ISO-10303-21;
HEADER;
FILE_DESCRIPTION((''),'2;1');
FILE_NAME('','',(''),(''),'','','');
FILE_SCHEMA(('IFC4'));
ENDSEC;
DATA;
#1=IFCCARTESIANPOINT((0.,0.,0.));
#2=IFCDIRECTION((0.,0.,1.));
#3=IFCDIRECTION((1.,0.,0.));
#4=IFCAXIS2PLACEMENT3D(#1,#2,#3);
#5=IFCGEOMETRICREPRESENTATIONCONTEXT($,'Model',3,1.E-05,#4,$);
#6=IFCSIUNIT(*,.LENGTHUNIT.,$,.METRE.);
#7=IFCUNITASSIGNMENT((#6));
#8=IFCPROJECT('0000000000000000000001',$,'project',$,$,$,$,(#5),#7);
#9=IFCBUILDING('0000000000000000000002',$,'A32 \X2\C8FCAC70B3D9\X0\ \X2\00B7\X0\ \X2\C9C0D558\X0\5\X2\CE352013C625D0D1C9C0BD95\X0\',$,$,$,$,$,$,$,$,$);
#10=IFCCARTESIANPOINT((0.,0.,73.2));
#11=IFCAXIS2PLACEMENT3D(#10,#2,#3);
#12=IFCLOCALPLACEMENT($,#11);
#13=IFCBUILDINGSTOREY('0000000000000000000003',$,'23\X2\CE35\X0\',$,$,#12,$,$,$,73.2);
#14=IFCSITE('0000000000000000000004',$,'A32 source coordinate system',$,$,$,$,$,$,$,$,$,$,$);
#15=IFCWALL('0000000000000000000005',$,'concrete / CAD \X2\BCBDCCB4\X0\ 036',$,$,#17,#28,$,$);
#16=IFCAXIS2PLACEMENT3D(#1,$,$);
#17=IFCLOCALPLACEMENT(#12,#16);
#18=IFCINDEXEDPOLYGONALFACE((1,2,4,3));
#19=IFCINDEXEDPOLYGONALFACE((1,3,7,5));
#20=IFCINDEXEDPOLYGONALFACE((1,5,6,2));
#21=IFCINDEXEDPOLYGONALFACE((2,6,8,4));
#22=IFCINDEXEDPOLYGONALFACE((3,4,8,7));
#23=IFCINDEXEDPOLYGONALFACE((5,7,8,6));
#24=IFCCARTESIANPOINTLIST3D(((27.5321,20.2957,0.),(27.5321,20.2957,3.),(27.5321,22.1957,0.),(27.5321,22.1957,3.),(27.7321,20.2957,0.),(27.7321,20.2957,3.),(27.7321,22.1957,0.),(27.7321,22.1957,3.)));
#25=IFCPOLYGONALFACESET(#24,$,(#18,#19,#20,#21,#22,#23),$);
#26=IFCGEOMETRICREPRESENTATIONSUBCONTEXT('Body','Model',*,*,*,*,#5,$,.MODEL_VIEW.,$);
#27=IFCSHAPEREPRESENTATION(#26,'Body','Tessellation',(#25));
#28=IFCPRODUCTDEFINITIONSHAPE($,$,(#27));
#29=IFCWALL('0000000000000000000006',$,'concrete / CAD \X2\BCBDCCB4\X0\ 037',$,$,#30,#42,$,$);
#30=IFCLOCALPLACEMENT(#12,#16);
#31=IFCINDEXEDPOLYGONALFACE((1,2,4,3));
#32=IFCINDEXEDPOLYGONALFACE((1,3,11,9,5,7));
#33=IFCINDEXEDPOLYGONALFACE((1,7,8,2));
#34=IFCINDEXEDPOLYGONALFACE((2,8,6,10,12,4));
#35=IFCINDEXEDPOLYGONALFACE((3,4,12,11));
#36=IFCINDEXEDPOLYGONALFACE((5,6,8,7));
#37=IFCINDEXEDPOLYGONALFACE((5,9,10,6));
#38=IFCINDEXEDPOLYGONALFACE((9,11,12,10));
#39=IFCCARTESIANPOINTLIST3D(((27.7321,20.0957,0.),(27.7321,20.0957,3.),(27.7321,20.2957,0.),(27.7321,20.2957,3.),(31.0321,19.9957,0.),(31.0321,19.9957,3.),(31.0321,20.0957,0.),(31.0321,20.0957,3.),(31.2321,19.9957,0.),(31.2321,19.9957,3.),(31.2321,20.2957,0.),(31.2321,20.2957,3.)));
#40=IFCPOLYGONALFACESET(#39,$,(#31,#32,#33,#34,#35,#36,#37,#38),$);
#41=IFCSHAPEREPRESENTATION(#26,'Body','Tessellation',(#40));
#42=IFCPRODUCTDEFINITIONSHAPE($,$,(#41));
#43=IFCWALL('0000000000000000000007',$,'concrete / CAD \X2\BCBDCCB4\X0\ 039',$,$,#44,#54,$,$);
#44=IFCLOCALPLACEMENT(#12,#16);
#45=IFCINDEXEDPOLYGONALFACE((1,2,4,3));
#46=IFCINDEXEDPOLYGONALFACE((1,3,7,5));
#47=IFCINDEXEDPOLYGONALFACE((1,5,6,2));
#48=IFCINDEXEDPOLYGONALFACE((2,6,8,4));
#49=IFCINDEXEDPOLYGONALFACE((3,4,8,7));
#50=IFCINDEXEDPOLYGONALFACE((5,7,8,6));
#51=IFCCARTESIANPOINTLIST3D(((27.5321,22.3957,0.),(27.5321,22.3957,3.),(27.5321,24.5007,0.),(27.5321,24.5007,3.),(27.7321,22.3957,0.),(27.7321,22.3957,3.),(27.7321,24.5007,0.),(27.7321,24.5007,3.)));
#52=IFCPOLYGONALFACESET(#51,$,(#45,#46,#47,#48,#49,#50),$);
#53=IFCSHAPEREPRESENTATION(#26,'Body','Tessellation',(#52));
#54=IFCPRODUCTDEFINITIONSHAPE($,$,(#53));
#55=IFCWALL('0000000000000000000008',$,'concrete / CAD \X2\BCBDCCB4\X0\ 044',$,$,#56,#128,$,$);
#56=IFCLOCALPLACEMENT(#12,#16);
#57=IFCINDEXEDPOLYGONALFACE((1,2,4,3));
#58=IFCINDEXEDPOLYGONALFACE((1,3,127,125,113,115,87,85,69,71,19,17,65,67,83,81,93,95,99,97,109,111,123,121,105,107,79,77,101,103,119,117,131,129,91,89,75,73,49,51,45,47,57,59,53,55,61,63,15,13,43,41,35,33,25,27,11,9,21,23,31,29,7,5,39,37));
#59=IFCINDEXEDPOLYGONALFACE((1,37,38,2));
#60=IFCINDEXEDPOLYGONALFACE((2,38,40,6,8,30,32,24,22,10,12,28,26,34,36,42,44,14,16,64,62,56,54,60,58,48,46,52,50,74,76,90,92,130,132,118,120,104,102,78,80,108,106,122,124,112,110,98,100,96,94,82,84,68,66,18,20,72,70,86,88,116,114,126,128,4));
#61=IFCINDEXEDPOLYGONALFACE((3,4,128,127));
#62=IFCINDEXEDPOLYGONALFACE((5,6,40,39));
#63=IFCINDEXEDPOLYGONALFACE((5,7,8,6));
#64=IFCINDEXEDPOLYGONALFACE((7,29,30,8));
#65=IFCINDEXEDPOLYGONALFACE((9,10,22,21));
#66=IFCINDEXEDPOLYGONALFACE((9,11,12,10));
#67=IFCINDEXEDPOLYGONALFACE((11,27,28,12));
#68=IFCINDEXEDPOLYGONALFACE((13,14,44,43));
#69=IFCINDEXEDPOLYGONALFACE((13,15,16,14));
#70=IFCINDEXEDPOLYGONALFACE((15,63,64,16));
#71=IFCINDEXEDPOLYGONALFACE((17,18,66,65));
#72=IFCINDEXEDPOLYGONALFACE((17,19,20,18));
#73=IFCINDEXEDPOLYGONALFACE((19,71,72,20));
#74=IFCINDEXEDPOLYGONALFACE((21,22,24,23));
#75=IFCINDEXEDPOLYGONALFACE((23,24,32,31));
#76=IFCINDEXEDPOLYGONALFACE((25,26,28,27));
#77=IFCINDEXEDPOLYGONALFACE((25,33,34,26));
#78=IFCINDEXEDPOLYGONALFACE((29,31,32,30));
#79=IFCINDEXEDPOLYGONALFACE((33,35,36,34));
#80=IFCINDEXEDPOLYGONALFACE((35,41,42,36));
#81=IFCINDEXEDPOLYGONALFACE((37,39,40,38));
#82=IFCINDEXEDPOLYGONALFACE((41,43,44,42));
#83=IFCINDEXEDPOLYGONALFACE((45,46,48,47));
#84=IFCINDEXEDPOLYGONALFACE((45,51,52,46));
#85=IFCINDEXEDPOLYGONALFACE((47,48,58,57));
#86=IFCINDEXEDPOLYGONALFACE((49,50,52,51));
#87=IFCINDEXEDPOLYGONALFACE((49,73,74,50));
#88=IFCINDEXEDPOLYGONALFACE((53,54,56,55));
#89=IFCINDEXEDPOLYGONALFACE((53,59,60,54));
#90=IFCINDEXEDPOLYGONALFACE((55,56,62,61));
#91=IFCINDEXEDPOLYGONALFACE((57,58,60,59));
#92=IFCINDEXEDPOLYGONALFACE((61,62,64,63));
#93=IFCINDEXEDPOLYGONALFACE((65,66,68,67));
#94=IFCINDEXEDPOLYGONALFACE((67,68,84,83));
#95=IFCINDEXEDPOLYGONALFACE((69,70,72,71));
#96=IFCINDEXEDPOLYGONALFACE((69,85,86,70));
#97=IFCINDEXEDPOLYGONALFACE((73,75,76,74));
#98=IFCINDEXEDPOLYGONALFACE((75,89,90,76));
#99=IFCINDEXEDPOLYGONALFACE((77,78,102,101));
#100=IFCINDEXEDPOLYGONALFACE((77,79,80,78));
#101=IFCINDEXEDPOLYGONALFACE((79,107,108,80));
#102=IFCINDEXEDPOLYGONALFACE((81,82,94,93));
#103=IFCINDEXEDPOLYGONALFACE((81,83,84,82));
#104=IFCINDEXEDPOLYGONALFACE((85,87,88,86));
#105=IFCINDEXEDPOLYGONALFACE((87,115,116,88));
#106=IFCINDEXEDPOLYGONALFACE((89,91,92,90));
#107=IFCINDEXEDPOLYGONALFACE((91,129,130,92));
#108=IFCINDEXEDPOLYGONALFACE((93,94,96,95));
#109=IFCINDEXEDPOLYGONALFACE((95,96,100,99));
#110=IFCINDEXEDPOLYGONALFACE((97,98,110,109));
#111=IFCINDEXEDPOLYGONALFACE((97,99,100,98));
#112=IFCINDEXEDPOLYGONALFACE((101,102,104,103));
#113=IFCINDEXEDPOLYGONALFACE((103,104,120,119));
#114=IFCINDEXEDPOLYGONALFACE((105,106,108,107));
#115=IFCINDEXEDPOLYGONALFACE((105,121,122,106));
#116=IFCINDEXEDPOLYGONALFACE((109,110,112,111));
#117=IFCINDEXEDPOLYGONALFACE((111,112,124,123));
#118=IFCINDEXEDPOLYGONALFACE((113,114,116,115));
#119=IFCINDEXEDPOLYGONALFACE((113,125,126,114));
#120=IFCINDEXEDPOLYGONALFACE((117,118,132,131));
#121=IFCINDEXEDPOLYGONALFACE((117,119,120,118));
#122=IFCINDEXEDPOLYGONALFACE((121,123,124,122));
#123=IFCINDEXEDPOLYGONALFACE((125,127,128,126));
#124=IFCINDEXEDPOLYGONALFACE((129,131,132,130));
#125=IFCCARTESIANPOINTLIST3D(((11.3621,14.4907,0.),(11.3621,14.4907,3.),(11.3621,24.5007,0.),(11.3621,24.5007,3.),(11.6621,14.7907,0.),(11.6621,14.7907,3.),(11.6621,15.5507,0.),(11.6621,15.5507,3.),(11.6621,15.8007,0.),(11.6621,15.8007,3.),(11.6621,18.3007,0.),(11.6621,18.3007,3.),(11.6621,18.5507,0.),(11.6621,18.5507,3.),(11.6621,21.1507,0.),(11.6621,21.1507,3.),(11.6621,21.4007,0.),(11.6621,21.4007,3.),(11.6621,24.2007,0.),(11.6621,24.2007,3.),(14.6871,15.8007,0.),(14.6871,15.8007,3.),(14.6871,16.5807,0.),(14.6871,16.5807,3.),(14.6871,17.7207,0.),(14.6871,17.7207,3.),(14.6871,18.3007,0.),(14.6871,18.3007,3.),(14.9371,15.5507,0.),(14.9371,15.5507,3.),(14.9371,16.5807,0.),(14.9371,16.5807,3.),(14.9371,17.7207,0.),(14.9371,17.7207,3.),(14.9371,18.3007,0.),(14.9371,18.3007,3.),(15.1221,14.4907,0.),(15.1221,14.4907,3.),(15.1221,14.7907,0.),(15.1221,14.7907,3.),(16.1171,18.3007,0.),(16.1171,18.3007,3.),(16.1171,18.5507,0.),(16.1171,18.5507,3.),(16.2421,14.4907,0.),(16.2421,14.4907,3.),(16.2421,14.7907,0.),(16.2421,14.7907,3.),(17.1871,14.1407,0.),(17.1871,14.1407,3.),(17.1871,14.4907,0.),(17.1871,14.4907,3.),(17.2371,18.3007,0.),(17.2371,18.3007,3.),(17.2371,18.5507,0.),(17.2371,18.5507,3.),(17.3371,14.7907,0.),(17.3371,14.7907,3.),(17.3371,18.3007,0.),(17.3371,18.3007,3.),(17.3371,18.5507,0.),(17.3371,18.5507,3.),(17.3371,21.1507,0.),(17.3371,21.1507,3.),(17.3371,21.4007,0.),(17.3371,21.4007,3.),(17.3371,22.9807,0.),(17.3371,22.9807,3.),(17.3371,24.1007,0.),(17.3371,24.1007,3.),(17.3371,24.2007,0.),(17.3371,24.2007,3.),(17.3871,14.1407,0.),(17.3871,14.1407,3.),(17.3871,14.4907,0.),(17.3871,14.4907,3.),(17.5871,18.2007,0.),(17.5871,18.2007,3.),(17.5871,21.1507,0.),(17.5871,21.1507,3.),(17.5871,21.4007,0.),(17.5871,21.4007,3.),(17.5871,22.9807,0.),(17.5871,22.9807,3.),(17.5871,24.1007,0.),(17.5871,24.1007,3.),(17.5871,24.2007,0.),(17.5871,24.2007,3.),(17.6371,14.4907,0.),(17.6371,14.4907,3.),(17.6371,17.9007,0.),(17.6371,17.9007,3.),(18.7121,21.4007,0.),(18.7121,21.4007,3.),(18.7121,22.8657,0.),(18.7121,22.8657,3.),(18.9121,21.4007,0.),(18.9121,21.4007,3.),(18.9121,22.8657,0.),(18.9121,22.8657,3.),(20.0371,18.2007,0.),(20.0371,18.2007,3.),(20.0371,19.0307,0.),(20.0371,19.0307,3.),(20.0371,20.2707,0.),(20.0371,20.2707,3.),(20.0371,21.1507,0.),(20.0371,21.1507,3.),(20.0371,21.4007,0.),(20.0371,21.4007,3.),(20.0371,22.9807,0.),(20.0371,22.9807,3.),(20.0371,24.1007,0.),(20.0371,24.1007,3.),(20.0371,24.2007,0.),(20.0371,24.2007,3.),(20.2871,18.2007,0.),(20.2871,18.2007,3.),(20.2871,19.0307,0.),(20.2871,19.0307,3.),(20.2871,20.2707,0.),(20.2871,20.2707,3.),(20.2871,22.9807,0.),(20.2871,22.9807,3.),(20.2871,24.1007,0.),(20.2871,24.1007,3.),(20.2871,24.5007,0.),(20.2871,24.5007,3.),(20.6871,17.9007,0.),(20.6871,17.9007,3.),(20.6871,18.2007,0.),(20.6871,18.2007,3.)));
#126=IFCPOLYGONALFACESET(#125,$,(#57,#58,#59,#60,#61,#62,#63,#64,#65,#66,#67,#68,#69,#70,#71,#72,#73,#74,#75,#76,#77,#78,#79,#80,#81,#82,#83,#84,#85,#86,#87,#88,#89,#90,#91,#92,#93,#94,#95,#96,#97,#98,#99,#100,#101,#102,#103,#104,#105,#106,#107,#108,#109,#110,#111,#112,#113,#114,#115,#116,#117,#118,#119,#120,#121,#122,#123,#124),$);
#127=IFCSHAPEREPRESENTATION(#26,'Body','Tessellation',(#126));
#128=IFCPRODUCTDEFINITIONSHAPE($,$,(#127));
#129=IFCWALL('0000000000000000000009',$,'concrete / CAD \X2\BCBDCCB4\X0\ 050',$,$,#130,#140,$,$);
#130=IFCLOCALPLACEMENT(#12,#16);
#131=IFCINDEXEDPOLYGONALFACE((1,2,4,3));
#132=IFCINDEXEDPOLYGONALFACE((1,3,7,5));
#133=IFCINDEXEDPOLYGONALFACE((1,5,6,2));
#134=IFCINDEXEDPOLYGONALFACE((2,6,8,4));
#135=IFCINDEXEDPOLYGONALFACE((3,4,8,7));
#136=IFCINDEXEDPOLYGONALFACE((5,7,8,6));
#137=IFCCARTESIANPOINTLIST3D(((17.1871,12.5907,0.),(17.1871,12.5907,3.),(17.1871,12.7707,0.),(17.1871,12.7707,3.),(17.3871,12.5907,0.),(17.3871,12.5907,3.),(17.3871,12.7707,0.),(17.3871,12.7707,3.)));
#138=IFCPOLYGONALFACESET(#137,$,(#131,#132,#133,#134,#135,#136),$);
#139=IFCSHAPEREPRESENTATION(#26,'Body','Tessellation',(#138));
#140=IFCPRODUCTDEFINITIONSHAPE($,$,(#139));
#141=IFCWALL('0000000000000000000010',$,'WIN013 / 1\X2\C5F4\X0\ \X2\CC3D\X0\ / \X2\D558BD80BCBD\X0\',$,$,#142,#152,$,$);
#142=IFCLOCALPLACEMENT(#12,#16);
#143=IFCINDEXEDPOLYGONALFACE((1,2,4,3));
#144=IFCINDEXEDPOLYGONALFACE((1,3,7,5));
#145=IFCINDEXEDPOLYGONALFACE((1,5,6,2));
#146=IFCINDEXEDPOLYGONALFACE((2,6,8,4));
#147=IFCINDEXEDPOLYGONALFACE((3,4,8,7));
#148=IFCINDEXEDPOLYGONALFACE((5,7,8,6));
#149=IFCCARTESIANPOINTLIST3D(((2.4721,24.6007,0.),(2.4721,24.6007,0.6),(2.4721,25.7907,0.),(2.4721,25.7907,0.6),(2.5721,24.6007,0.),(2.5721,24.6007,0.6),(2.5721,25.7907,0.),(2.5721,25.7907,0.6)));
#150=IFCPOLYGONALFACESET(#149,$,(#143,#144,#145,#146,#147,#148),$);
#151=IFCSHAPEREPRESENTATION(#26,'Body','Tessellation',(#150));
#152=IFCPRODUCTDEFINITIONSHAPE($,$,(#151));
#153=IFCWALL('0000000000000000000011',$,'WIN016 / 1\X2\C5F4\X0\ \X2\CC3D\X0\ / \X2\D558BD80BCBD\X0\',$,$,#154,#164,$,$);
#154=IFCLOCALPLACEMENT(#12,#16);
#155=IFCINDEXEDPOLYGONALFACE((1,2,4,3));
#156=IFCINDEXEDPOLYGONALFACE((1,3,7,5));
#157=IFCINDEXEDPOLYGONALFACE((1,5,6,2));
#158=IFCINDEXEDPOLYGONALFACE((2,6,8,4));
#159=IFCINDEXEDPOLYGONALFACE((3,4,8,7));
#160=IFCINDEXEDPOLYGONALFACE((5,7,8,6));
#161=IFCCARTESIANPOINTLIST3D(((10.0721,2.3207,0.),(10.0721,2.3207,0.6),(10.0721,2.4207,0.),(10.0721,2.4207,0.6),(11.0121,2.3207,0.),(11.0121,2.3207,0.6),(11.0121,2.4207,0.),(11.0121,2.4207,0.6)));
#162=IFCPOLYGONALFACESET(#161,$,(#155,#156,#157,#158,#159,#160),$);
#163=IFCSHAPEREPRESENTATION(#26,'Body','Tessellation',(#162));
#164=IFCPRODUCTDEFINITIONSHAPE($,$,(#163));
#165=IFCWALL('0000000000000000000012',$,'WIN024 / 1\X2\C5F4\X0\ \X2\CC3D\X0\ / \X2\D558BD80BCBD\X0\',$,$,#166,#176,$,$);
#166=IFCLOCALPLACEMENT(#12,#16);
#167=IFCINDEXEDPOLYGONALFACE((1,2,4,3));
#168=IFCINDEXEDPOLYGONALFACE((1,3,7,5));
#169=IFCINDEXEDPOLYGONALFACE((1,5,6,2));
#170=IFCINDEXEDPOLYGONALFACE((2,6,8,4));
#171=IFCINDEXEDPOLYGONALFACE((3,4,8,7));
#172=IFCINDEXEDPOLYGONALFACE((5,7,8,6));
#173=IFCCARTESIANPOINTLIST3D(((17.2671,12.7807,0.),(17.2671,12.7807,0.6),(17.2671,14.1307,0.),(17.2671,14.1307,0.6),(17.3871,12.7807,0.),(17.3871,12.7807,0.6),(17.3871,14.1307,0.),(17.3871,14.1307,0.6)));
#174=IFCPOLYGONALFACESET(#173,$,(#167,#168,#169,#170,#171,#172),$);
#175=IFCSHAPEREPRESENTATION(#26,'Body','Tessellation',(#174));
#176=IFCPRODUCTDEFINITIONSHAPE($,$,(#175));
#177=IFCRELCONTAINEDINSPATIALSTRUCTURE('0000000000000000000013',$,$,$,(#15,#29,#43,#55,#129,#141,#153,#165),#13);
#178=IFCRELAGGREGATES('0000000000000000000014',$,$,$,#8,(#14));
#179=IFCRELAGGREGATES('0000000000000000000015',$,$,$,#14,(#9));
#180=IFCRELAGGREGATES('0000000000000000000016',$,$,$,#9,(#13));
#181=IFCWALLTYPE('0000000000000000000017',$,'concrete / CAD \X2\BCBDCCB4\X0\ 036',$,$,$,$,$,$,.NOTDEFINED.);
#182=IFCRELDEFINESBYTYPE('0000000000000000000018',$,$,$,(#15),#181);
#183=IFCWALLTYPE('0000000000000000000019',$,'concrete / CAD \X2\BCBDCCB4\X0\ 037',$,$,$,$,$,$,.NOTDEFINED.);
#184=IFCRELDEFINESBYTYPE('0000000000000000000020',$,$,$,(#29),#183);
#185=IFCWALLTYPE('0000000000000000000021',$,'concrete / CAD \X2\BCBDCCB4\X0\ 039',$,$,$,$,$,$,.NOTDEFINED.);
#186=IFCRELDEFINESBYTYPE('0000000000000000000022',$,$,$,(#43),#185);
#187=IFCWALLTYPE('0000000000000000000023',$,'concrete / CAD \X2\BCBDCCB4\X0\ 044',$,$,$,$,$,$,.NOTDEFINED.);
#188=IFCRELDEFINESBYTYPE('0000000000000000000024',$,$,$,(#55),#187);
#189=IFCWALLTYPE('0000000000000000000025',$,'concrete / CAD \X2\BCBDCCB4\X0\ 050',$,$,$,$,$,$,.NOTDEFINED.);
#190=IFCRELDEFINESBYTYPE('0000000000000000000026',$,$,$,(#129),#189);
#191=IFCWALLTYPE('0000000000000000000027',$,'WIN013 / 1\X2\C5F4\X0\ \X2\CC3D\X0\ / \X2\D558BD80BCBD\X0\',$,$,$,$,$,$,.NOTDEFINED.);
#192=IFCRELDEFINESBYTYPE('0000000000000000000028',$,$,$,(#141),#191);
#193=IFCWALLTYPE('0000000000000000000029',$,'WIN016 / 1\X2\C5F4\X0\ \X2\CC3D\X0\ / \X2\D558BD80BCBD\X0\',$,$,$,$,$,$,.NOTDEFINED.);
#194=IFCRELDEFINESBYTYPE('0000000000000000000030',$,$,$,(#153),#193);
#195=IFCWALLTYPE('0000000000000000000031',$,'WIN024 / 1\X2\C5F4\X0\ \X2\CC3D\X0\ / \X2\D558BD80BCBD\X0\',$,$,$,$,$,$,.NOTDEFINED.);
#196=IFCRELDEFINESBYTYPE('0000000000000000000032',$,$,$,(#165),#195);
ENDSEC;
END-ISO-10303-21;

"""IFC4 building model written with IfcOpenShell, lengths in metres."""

from ifc_helpers import new_model, si_unit, frame, origin, origin_with_axes, place, context, subcontext, project, spatial, polyline, outline, extrude, source, transform, mapped, type_object, type_shapes, element, save


model = new_model("IFC4")

# Units and contexts
model_context = context("Model", 3, precision=1e-05, world=origin_with_axes())
body_context = subcontext(model_context, "Body", "Model", "MODEL_VIEW")
ifc_project = project(units=[si_unit("LENGTHUNIT", "METRE")], contexts=[model_context])

# Site, building, storey
site = spatial("IfcSite", under=ifc_project, Name="A32 source coordinate system")
building = spatial("IfcBuilding", under=site, Name="A32 주거동 · 지하5층–옥탑지붕")
storey_placement = place(None, frame((0.0, 0.0, 73.2), z_axis=(0.0, 0.0, 1.0), x_axis=(1.0, 0.0, 0.0)))
storey = spatial("IfcBuildingStorey", under=building, at=storey_placement, Name="23층", Elevation=73.2)

# Walls
wall_type_1 = type_object("IfcWallType", Name="concrete / CAD 벽체 036", PredefinedType="NOTDEFINED")
shared_shape_1 = source(origin(), body_context, "Body", "SweptSolid", [
    extrude(outline(polyline([(27.7321, 22.1957), (27.7321, 20.2957), (27.5321, 20.2957), (27.5321, 22.1957), (27.7321, 22.1957)])), origin(), (0.0, 0.0, 1.0), 3.0),
])
type_shapes(wall_type_1, [shared_shape_1])
wall_1_placement = place(storey_placement, origin_with_axes())
element("IfcWall", 1, at=wall_1_placement, inside=storey, type_object=wall_type_1, Name="concrete / CAD 벽체 036", context=body_context, shape_type="MappedRepresentation", body=[
    mapped(shared_shape_1, transform((0.0, 0.0, 0.0), scale=1.0)),
])
wall_type_2 = type_object("IfcWallType", Name="concrete / CAD 벽체 037", PredefinedType="NOTDEFINED")
shared_shape_2 = source(origin(), body_context, "Body", "SweptSolid", [
    extrude(outline(polyline([(31.2321, 19.9957), (31.0321, 19.9957), (31.0321, 20.0957), (27.7321, 20.0957), (27.7321, 20.2957), (31.2321, 20.2957), (31.2321, 19.9957)])), origin(), (0.0, 0.0, 1.0), 3.0),
])
type_shapes(wall_type_2, [shared_shape_2])
wall_2_placement = place(storey_placement, origin_with_axes())
element("IfcWall", 2, at=wall_2_placement, inside=storey, type_object=wall_type_2, Name="concrete / CAD 벽체 037", context=body_context, shape_type="MappedRepresentation", body=[
    mapped(shared_shape_2, transform((0.0, 0.0, 0.0), scale=1.0)),
])
wall_type_3 = type_object("IfcWallType", Name="concrete / CAD 벽체 039", PredefinedType="NOTDEFINED")
shared_shape_3 = source(origin(), body_context, "Body", "SweptSolid", [
    extrude(outline(polyline([(27.7321, 24.5007), (27.7321, 22.3957), (27.5321, 22.3957), (27.5321, 24.5007), (27.7321, 24.5007)])), origin(), (0.0, 0.0, 1.0), 3.0),
])
type_shapes(wall_type_3, [shared_shape_3])
wall_3_placement = place(storey_placement, origin_with_axes())
element("IfcWall", 3, at=wall_3_placement, inside=storey, type_object=wall_type_3, Name="concrete / CAD 벽체 039", context=body_context, shape_type="MappedRepresentation", body=[
    mapped(shared_shape_3, transform((0.0, 0.0, 0.0), scale=1.0)),
])
wall_type_4 = type_object("IfcWallType", Name="concrete / CAD 벽체 044", PredefinedType="NOTDEFINED")
shared_shape_4 = source(origin(), body_context, "Body", "SweptSolid", [
    extrude(outline(polyline([(17.3371, 21.4007), (17.3371, 22.9807), (17.5871, 22.9807), (17.5871, 21.4007), (18.7121, 21.4007), (18.7121, 22.8657), (18.9121, 22.8657), (18.9121, 21.4007), (20.0371, 21.4007), (20.0371, 22.9807), (20.2871, 22.9807), (20.2871, 20.2707), (20.0371, 20.2707), (20.0371, 21.1507), (17.5871, 21.1507), (17.5871, 18.2007), (20.0371, 18.2007), (20.0371, 19.0307), (20.2871, 19.0307), (20.2871, 18.2007), (20.6871, 18.2007), (20.6871, 17.9007), (17.6371, 17.9007), (17.6371, 14.4907), (17.3871, 14.4907), (17.3871, 14.1407), (17.1871, 14.1407), (17.1871, 14.4907), (16.2421, 14.4907), (16.2421, 14.7907), (17.3371, 14.7907), (17.3371, 18.3007), (17.2371, 18.3007), (17.2371, 18.5507), (17.3371, 18.5507), (17.3371, 21.1507), (11.6621, 21.1507), (11.6621, 18.5507), (16.1171, 18.5507), (16.1171, 18.3007), (14.9371, 18.3007), (14.9371, 17.7207), (14.6871, 17.7207), (14.6871, 18.3007), (11.6621, 18.3007), (11.6621, 15.8007), (14.6871, 15.8007), (14.6871, 16.5807), (14.9371, 16.5807), (14.9371, 15.5507), (11.6621, 15.5507), (11.6621, 14.7907), (15.1221, 14.7907), (15.1221, 14.4907), (11.3621, 14.4907), (11.3621, 24.5007), (20.2871, 24.5007), (20.2871, 24.1007), (20.0371, 24.1007), (20.0371, 24.2007), (17.5871, 24.2007), (17.5871, 24.1007), (17.3371, 24.1007), (17.3371, 24.2007), (11.6621, 24.2007), (11.6621, 21.4007), (17.3371, 21.4007)])), origin(), (0.0, 0.0, 1.0), 3.0),
])
type_shapes(wall_type_4, [shared_shape_4])
wall_4_placement = place(storey_placement, origin_with_axes())
element("IfcWall", 4, at=wall_4_placement, inside=storey, type_object=wall_type_4, Name="concrete / CAD 벽체 044", context=body_context, shape_type="MappedRepresentation", body=[
    mapped(shared_shape_4, transform((0.0, 0.0, 0.0), scale=1.0)),
])
wall_type_5 = type_object("IfcWallType", Name="concrete / CAD 벽체 050", PredefinedType="NOTDEFINED")
shared_shape_5 = source(origin(), body_context, "Body", "SweptSolid", [
    extrude(outline(polyline([(17.3871, 12.5907), (17.1871, 12.5907), (17.1871, 12.7707), (17.3871, 12.7707), (17.3871, 12.5907)])), origin(), (0.0, 0.0, 1.0), 3.0),
])
type_shapes(wall_type_5, [shared_shape_5])
wall_5_placement = place(storey_placement, origin_with_axes())
element("IfcWall", 5, at=wall_5_placement, inside=storey, type_object=wall_type_5, Name="concrete / CAD 벽체 050", context=body_context, shape_type="MappedRepresentation", body=[
    mapped(shared_shape_5, transform((0.0, 0.0, 0.0), scale=1.0)),
])
wall_type_6 = type_object("IfcWallType", Name="WIN013 / 1열 창 / 하부벽", PredefinedType="NOTDEFINED")
shared_shape_6 = source(origin(), body_context, "Body", "SweptSolid", [
    extrude(outline(polyline([(2.5721, 25.7907), (2.5721, 24.6007), (2.4721, 24.6007), (2.4721, 25.7907), (2.5721, 25.7907)])), origin(), (0.0, 0.0, 1.0), 0.6),
])
type_shapes(wall_type_6, [shared_shape_6])
wall_6_placement = place(storey_placement, origin_with_axes())
element("IfcWall", 6, at=wall_6_placement, inside=storey, type_object=wall_type_6, Name="WIN013 / 1열 창 / 하부벽", context=body_context, shape_type="MappedRepresentation", body=[
    mapped(shared_shape_6, transform((0.0, 0.0, 0.0), scale=1.0)),
])
wall_type_7 = type_object("IfcWallType", Name="WIN016 / 1열 창 / 하부벽", PredefinedType="NOTDEFINED")
shared_shape_7 = source(origin(), body_context, "Body", "SweptSolid", [
    extrude(outline(polyline([(11.0121, 2.4207), (11.0121, 2.3207), (10.0721, 2.3207), (10.0721, 2.4207), (11.0121, 2.4207)])), origin(), (0.0, 0.0, 1.0), 0.6),
])
type_shapes(wall_type_7, [shared_shape_7])
wall_7_placement = place(storey_placement, origin_with_axes())
element("IfcWall", 7, at=wall_7_placement, inside=storey, type_object=wall_type_7, Name="WIN016 / 1열 창 / 하부벽", context=body_context, shape_type="MappedRepresentation", body=[
    mapped(shared_shape_7, transform((0.0, 0.0, 0.0), scale=1.0)),
])
wall_type_8 = type_object("IfcWallType", Name="WIN024 / 1열 창 / 하부벽", PredefinedType="NOTDEFINED")
shared_shape_8 = source(origin(), body_context, "Body", "SweptSolid", [
    extrude(outline(polyline([(17.3871, 14.1307), (17.3871, 12.7807), (17.2671, 12.7807), (17.2671, 14.1307), (17.3871, 14.1307)])), origin(), (0.0, 0.0, 1.0), 0.6),
])
type_shapes(wall_type_8, [shared_shape_8])
wall_8_placement = place(storey_placement, origin_with_axes())
element("IfcWall", 8, at=wall_8_placement, inside=storey, type_object=wall_type_8, Name="WIN024 / 1열 창 / 하부벽", context=body_context, shape_type="MappedRepresentation", body=[
    mapped(shared_shape_8, transform((0.0, 0.0, 0.0), scale=1.0)),
])

save(model, "model.ifc")
